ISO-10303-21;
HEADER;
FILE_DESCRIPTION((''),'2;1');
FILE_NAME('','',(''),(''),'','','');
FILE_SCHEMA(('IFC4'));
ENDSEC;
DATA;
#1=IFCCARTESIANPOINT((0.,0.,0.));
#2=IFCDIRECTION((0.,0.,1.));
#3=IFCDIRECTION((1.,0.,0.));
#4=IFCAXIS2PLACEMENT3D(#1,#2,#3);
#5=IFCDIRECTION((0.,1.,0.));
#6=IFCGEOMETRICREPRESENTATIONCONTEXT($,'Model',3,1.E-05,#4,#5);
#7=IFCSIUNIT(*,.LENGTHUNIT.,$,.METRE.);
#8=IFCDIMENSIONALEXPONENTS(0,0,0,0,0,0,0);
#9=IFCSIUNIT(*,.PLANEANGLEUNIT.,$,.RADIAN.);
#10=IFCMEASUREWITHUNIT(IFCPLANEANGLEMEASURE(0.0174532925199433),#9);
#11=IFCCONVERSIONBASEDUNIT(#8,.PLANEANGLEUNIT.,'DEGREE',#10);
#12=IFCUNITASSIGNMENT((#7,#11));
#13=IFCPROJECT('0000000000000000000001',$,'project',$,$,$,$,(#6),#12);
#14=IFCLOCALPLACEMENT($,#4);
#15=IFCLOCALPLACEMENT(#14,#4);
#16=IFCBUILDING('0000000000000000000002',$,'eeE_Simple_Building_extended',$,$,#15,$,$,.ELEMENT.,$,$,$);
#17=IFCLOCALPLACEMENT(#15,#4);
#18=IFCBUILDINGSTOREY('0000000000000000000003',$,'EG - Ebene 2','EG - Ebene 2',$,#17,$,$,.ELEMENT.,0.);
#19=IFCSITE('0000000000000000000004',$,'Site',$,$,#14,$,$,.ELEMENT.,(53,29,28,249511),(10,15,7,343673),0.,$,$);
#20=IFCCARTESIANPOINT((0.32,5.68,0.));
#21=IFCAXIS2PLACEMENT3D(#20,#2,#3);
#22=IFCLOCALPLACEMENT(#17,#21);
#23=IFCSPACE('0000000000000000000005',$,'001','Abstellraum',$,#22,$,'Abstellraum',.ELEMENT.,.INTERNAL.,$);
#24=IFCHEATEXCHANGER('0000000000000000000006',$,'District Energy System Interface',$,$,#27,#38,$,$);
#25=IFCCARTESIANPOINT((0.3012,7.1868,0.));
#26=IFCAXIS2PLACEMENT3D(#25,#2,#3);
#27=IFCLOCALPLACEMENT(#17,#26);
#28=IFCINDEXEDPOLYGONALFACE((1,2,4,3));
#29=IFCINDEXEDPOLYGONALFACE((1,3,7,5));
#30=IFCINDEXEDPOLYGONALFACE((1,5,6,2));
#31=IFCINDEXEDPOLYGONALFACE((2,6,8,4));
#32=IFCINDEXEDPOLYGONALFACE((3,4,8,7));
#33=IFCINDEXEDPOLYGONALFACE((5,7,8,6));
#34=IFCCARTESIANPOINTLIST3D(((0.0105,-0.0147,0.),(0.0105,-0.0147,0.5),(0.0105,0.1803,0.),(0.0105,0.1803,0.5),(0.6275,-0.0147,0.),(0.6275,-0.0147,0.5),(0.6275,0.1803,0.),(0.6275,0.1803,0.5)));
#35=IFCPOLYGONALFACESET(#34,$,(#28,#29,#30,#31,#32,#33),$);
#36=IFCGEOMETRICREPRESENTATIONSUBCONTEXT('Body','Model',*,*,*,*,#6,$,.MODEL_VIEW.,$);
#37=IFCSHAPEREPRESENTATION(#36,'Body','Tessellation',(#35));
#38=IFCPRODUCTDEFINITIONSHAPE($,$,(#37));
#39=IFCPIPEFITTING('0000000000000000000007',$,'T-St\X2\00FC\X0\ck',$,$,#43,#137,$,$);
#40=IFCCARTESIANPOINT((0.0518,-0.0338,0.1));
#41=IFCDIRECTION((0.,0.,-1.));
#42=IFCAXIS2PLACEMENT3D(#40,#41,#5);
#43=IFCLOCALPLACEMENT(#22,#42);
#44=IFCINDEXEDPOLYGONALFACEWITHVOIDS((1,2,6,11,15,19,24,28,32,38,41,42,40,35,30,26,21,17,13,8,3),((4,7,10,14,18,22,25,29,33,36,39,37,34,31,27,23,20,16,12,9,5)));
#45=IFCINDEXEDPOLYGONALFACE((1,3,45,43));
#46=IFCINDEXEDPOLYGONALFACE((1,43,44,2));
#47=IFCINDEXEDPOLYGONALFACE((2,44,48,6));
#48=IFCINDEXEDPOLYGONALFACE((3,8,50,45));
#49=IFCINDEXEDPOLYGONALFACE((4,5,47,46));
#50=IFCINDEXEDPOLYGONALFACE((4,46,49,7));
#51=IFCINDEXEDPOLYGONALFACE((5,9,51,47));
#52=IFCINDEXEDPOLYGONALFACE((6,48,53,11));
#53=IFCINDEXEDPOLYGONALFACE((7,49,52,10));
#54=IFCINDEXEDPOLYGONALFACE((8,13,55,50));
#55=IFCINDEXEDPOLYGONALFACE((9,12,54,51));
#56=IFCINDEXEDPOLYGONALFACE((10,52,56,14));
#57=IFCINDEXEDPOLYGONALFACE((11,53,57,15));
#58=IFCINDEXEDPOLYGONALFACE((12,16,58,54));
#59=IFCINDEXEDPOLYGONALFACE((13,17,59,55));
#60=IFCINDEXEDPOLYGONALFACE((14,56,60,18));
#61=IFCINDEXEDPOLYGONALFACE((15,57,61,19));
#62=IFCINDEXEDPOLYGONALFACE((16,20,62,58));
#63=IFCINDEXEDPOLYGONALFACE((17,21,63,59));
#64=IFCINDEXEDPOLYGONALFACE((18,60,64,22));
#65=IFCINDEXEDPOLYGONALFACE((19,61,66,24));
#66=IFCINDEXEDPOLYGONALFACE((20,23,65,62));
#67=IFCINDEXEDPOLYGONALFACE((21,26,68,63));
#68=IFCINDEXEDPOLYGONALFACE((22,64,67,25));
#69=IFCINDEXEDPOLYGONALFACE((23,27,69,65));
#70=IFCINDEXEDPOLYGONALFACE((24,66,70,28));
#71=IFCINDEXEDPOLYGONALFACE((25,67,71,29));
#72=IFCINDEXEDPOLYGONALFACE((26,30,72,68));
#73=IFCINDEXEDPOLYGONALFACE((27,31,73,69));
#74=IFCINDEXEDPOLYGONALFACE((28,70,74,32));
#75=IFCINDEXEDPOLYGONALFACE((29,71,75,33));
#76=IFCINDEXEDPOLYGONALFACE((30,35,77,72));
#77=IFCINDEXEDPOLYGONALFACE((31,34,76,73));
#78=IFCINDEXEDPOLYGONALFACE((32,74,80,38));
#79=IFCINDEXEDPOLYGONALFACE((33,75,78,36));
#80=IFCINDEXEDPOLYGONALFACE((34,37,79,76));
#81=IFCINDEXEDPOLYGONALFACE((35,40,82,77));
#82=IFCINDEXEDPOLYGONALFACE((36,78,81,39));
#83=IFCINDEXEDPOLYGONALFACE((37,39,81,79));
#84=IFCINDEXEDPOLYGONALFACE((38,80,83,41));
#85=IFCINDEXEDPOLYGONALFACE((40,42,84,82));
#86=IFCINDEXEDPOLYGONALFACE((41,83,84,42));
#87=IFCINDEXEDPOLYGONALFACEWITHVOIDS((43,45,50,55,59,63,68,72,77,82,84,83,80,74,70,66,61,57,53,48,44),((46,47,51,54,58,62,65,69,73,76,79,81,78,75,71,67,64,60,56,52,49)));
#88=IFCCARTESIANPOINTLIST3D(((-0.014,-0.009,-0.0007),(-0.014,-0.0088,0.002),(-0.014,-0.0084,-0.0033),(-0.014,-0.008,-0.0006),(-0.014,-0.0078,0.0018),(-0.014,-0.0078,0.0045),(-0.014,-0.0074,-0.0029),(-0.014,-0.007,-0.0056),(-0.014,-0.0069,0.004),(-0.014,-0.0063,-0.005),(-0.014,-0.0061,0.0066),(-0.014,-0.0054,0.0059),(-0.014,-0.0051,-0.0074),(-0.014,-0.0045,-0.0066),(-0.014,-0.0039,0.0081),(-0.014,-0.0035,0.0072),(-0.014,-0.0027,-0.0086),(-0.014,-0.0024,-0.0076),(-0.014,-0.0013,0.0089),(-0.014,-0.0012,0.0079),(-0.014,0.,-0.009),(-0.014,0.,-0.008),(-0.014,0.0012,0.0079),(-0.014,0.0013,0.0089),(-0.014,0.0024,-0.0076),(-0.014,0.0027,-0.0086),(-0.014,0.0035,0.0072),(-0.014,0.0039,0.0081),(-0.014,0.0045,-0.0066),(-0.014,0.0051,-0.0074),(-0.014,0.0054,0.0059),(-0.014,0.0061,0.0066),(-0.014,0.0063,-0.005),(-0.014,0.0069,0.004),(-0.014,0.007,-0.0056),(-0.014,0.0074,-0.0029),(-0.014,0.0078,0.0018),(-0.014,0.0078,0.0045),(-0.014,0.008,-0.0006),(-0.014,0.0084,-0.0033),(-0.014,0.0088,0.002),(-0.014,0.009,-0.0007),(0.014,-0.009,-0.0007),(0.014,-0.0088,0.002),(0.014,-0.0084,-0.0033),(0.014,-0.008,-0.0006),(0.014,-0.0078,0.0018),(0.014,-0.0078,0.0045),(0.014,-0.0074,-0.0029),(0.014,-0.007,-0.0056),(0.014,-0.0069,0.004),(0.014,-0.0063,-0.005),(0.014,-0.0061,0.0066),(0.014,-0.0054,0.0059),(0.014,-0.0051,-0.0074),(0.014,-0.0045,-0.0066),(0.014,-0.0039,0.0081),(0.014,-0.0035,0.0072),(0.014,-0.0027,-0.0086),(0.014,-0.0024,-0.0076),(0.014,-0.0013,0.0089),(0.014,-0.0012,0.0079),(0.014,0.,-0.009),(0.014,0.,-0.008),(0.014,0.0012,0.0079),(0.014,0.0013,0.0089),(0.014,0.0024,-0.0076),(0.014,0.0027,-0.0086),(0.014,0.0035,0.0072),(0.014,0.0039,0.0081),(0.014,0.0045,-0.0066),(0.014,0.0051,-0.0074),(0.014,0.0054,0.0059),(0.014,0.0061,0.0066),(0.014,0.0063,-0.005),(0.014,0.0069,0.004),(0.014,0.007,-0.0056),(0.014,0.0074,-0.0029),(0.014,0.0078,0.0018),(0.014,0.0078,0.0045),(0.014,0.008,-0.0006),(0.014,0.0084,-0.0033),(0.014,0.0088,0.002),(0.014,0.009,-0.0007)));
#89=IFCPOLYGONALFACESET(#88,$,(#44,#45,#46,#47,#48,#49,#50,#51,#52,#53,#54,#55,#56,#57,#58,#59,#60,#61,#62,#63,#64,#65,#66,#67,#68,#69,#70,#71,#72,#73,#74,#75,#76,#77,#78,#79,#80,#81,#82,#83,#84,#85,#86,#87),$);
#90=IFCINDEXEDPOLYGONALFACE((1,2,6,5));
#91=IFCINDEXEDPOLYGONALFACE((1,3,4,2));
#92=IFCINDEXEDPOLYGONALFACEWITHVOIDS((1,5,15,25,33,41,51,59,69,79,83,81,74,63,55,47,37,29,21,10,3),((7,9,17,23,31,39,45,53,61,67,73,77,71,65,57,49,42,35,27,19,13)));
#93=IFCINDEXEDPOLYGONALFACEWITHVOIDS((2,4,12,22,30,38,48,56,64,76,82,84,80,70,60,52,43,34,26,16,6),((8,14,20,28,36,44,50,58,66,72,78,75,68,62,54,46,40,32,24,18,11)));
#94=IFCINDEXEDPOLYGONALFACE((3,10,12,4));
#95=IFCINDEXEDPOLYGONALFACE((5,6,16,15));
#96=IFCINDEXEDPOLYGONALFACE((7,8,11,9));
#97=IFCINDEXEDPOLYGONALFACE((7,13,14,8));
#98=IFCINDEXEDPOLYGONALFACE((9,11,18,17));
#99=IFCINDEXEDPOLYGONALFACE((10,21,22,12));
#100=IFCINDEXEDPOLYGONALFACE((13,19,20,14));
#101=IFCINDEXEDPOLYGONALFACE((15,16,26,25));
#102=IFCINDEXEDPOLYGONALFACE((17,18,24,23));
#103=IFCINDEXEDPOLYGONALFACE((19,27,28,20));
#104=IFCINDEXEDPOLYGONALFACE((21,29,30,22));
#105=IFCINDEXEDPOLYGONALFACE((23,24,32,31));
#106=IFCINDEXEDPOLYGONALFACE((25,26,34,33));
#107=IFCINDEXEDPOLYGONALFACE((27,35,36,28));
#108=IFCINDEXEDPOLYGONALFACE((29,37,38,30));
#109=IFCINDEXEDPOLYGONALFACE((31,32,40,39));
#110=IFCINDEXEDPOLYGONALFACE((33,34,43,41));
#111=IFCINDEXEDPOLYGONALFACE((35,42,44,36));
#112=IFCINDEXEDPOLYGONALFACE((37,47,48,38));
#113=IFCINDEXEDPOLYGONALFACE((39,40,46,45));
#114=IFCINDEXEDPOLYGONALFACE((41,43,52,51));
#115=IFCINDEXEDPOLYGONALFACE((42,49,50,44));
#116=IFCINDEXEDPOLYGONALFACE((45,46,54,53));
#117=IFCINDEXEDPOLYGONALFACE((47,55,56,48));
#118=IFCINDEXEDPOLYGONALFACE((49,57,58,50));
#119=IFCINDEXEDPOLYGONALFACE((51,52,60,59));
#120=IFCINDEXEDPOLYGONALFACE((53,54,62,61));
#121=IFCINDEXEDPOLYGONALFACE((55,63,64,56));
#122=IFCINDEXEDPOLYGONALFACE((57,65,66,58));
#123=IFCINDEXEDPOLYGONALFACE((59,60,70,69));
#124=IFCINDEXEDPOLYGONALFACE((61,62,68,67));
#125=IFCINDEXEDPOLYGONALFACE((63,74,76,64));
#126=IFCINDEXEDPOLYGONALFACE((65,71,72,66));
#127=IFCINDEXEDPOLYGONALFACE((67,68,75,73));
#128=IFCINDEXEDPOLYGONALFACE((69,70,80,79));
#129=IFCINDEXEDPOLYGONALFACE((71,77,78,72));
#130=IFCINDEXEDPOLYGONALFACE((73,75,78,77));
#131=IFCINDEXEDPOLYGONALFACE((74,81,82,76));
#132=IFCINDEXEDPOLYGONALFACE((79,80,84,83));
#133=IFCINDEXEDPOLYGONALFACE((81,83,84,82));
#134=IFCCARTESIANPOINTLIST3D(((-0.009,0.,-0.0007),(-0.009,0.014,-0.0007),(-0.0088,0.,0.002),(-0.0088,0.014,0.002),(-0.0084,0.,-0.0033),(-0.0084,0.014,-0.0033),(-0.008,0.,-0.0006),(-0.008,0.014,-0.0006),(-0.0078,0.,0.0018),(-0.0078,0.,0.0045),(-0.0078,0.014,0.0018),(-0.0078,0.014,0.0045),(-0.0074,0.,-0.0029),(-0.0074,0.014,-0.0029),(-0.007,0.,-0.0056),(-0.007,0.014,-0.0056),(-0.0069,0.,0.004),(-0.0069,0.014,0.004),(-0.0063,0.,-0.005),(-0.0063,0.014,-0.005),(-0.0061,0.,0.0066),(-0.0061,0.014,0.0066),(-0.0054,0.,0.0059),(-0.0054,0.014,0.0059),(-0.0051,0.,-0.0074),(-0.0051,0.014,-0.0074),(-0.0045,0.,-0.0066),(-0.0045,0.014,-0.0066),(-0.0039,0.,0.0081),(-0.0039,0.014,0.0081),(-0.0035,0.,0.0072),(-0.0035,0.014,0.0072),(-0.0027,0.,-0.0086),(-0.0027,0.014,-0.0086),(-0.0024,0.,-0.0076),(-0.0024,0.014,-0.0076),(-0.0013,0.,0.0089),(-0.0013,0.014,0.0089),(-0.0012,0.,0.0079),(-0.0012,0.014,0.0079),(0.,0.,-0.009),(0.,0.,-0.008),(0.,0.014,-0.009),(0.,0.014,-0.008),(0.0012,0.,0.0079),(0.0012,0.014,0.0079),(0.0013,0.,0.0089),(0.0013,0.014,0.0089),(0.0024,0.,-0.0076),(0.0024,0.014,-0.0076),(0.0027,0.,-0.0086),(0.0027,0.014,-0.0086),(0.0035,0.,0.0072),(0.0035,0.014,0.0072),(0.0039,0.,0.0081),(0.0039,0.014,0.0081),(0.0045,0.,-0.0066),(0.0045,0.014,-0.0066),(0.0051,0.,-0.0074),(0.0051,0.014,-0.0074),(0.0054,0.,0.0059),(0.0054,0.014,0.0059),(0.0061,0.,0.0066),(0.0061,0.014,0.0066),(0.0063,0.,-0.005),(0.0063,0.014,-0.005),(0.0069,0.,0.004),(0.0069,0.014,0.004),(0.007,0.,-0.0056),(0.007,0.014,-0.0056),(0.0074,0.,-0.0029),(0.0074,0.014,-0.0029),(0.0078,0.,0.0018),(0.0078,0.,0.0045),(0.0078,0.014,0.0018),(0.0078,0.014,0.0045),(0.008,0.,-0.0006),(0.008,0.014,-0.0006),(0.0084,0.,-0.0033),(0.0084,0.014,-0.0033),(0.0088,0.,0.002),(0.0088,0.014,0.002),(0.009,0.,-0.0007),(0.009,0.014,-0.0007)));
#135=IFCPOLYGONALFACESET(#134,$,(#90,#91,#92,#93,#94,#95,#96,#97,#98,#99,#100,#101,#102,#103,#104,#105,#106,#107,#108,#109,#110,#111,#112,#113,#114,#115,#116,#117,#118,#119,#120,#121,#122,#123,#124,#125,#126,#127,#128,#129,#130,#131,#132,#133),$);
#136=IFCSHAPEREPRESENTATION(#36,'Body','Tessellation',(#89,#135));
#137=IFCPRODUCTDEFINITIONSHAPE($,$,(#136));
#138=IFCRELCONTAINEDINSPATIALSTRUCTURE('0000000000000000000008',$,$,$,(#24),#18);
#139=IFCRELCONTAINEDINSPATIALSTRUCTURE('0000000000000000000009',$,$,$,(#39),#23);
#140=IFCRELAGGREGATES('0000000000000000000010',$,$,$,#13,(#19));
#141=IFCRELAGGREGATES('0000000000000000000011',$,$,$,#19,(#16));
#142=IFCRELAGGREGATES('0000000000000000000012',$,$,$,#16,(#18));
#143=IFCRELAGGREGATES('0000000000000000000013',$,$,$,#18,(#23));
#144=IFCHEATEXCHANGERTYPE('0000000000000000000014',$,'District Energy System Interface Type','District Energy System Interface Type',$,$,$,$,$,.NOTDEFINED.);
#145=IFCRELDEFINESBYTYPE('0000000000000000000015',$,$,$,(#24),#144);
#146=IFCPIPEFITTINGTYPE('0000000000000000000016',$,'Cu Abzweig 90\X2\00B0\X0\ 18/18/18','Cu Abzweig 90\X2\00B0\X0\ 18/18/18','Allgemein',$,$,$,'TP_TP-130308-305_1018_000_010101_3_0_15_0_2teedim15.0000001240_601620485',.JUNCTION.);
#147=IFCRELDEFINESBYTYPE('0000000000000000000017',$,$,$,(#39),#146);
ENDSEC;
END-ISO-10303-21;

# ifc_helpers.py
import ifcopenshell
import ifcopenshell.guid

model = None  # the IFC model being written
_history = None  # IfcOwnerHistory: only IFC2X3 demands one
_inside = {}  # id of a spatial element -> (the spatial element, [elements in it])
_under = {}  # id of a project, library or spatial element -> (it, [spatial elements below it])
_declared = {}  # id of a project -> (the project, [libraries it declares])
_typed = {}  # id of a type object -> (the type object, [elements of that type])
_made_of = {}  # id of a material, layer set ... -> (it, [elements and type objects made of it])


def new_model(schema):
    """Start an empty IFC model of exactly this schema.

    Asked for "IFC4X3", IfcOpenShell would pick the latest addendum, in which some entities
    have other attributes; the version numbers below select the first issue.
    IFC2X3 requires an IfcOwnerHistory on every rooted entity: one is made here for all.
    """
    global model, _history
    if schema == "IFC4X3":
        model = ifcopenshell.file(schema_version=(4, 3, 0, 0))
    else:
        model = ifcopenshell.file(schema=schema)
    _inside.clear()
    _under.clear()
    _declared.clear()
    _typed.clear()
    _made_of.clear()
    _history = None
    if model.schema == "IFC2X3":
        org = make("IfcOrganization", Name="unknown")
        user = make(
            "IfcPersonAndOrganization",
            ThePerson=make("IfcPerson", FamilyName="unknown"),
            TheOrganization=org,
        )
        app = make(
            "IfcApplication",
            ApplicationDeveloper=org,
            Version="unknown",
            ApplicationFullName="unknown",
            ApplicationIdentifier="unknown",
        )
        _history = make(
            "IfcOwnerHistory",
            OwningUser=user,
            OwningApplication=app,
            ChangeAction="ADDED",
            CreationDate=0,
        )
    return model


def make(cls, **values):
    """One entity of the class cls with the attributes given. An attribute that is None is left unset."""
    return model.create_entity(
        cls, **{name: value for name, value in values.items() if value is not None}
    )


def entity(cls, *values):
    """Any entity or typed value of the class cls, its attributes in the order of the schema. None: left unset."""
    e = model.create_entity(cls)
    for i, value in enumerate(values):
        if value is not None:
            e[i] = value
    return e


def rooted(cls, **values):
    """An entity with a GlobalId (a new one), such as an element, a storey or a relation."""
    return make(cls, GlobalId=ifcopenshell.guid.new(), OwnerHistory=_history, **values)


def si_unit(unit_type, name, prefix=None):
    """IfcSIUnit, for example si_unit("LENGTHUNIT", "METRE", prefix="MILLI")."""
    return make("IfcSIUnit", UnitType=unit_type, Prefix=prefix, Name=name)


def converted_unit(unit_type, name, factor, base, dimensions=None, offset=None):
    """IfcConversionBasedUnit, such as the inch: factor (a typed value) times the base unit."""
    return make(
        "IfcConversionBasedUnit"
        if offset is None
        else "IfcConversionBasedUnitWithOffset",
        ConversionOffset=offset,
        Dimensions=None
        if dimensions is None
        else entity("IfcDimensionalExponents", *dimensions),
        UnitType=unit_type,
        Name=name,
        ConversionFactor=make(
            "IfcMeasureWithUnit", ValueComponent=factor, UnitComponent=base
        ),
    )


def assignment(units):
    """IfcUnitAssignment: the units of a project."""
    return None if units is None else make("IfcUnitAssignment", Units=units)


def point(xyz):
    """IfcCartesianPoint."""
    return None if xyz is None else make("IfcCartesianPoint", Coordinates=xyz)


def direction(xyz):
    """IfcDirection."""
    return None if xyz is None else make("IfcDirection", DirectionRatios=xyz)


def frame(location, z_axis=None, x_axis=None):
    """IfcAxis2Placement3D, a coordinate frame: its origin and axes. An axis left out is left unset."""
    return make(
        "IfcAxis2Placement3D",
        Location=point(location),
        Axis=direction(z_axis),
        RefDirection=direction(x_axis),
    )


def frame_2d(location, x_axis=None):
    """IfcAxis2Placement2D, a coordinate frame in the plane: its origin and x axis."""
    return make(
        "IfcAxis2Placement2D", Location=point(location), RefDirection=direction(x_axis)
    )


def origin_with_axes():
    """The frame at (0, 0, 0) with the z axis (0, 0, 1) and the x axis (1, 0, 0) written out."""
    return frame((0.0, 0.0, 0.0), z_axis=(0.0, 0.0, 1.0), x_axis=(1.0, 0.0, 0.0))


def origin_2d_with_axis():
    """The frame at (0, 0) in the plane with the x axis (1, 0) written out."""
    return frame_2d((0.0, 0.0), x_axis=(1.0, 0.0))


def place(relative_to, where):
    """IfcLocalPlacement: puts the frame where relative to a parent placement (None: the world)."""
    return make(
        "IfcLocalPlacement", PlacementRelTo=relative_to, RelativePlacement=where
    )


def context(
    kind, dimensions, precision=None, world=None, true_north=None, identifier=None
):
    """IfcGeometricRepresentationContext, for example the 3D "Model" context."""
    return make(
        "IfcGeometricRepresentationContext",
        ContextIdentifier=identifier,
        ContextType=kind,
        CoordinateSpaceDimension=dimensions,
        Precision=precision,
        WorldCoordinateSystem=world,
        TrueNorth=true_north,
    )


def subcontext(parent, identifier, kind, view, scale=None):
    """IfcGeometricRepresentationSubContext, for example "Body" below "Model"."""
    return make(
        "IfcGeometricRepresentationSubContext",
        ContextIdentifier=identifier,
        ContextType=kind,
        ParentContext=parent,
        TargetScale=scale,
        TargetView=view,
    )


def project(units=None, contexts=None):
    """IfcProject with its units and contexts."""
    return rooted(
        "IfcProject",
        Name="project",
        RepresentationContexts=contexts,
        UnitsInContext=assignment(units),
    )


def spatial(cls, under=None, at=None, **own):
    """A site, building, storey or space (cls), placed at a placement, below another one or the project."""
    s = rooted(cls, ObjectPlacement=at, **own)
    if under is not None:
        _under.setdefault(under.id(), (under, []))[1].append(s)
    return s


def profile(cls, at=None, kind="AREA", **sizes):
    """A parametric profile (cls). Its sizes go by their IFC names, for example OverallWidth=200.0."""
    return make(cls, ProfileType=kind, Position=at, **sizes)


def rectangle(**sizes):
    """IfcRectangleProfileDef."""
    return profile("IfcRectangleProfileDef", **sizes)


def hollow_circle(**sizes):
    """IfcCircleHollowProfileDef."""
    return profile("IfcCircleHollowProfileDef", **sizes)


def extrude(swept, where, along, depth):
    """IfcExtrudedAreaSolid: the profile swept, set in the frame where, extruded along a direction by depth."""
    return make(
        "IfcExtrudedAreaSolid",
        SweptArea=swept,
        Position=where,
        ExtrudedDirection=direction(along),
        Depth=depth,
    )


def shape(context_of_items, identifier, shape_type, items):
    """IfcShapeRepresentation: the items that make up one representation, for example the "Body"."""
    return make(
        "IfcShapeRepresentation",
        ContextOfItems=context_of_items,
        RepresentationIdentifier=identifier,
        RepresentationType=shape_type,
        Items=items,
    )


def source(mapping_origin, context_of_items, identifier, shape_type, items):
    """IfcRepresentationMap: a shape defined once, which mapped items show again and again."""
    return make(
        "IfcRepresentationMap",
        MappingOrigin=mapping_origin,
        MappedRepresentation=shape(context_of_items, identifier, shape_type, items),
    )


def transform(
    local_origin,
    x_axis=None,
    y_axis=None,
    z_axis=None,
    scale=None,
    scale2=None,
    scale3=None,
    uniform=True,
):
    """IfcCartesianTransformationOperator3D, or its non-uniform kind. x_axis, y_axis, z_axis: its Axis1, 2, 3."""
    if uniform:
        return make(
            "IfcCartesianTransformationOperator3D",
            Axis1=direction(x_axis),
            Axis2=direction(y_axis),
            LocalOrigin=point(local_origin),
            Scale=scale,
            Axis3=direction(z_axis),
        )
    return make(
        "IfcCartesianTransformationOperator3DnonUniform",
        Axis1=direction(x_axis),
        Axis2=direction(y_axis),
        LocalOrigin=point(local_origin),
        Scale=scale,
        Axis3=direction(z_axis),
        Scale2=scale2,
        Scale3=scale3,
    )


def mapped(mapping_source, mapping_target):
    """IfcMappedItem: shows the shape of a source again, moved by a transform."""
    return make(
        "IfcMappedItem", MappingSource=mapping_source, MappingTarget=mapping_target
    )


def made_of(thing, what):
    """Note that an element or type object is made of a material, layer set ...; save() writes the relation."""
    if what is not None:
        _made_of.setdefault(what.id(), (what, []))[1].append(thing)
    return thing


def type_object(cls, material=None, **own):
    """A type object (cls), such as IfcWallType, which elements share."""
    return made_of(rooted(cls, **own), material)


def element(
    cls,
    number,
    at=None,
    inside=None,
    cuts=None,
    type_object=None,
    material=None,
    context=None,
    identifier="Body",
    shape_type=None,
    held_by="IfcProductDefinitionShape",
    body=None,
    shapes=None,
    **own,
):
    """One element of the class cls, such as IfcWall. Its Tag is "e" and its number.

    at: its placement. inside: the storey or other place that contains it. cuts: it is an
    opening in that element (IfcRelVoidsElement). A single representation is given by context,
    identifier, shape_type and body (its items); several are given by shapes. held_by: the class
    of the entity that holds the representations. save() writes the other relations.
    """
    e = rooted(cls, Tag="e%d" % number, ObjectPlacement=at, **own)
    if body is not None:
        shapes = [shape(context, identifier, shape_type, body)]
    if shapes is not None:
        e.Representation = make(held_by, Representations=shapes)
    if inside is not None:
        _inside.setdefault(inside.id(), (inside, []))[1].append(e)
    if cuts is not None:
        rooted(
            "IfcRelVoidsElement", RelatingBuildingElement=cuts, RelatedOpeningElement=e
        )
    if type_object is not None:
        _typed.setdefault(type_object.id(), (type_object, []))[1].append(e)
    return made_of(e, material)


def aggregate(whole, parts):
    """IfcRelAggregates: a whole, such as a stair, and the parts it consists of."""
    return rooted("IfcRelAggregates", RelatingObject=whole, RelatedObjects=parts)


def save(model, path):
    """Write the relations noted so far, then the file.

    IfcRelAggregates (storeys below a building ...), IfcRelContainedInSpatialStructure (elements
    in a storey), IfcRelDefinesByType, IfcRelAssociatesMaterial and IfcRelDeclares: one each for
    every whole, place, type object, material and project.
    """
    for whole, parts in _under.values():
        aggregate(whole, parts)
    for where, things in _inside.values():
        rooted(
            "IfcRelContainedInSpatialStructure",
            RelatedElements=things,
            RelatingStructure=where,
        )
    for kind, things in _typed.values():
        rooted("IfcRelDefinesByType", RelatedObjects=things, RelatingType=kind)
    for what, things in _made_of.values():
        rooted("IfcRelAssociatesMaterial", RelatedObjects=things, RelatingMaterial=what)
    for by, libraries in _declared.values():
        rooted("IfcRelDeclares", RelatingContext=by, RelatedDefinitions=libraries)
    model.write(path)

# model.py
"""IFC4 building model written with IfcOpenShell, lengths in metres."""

from ifc_helpers import new_model, entity, si_unit, converted_unit, direction, frame, origin_with_axes, origin_2d_with_axis, place, context, subcontext, project, spatial, rectangle, hollow_circle, extrude, source, transform, mapped, type_object, element, save


model = new_model("IFC4")

# Units and contexts
model_context = context("Model", 3, precision=1e-05, world=origin_with_axes(), true_north=direction((0.0, 1.0, 0.0)))
body_context = subcontext(model_context, "Body", "Model", "MODEL_VIEW")
ifc_project = project(units=[si_unit("LENGTHUNIT", "METRE"), converted_unit("PLANEANGLEUNIT", "DEGREE", entity("IfcPlaneAngleMeasure", 0.0174532925199433), si_unit("PLANEANGLEUNIT", "RADIAN"), dimensions=[0, 0, 0, 0, 0, 0, 0])], contexts=[model_context])

# Site, building, storey
site_placement = place(None, origin_with_axes())
site = spatial("IfcSite", under=ifc_project, at=site_placement, Name="Site", CompositionType="ELEMENT", RefLatitude=(53, 29, 28, 249511), RefLongitude=(10, 15, 7, 343673), RefElevation=0.0)
building_placement = place(site_placement, origin_with_axes())
building = spatial("IfcBuilding", under=site, at=building_placement, Name="eeE_Simple_Building_extended", CompositionType="ELEMENT")
storey_placement = place(building_placement, origin_with_axes())
storey = spatial("IfcBuildingStorey", under=building, at=storey_placement, Name="EG - Ebene 2", Description="EG - Ebene 2", CompositionType="ELEMENT", Elevation=0.0)

# Heat exchanger
heat_exchanger_type = type_object("IfcHeatExchangerType", Name="District Energy System Interface Type", Description="District Energy System Interface Type", PredefinedType="NOTDEFINED")
shared_shape_1 = source(origin_with_axes(), body_context, "Body", "SweptSolid", [
    extrude(rectangle(XDim=0.617, YDim=0.195, at=origin_2d_with_axis()), frame((0.319, 0.0828, 0.0), z_axis=(0.0, 0.0, 1.0), x_axis=(1.0, 0.0, 0.0)), (0.0, 0.0, 1.0), 0.5),
])
heat_exchanger_placement = place(storey_placement, frame((0.3012, 7.1868, 0.0), z_axis=(0.0, 0.0, 1.0), x_axis=(1.0, 0.0, 0.0)))
element("IfcHeatExchanger", 1, at=heat_exchanger_placement, inside=storey, type_object=heat_exchanger_type, Name="District Energy System Interface", context=body_context, shape_type="MappedRepresentation", body=[
    mapped(shared_shape_1, transform((0.0, 0.0, 0.0), x_axis=(1.0, 0.0, 0.0), y_axis=(0.0, 1.0, 0.0), z_axis=(0.0, 0.0, 1.0), scale=1.0)),
])

# Shared definitions
space_placement = place(storey_placement, frame((0.32, 5.68, 0.0), z_axis=(0.0, 0.0, 1.0), x_axis=(1.0, 0.0, 0.0)))
space = spatial("IfcSpace", under=storey, at=space_placement, Name="001", Description="Abstellraum", LongName="Abstellraum", CompositionType="ELEMENT", PredefinedType="INTERNAL")

# Pipe fitting
pipe_fitting_type_1 = type_object("IfcPipeFittingType", Name="Cu Abzweig 90° 18/18/18", Description="Cu Abzweig 90° 18/18/18", ApplicableOccurrence="Allgemein", ElementType="TP_TP-130308-305_1018_000_010101_3_0_15_0_2teedim15.0000001240_601620485", PredefinedType="JUNCTION")
shared_shape_2 = source(origin_with_axes(), body_context, "Body", "SweptSolid", [
    extrude(hollow_circle(Radius=0.009, WallThickness=0.001, at=origin_2d_with_axis()), frame((0.0, 0.0, 0.0), z_axis=(1.0, 0.0, 0.0), x_axis=(0.0, 0.0, -1.0)), (0.0, 0.0, 1.0), 0.028),
    extrude(hollow_circle(Radius=0.009, WallThickness=0.001, at=origin_2d_with_axis()), frame((0.014, 0.0, 0.0), z_axis=(0.0, 1.0, 0.0), x_axis=(0.0, 0.0, -1.0)), (0.0, 0.0, 1.0), 0.014),
])
pipe_fitting_1_placement = place(space_placement, frame((0.0518, -0.0338, 0.1), z_axis=(0.0, 0.0, -1.0), x_axis=(0.0, 1.0, 0.0)))
element("IfcPipeFitting", 2, at=pipe_fitting_1_placement, inside=space, type_object=pipe_fitting_type_1, Name="T-Stück", context=body_context, shape_type="MappedRepresentation", body=[
    mapped(shared_shape_2, transform((-0.014, 0.0, 0.0), x_axis=(1.0, 0.0, 0.0), y_axis=(0.0, 1.0, 0.0), z_axis=(0.0, 0.0, 1.0), scale=1.0)),
])

save(model, "model.ifc")
